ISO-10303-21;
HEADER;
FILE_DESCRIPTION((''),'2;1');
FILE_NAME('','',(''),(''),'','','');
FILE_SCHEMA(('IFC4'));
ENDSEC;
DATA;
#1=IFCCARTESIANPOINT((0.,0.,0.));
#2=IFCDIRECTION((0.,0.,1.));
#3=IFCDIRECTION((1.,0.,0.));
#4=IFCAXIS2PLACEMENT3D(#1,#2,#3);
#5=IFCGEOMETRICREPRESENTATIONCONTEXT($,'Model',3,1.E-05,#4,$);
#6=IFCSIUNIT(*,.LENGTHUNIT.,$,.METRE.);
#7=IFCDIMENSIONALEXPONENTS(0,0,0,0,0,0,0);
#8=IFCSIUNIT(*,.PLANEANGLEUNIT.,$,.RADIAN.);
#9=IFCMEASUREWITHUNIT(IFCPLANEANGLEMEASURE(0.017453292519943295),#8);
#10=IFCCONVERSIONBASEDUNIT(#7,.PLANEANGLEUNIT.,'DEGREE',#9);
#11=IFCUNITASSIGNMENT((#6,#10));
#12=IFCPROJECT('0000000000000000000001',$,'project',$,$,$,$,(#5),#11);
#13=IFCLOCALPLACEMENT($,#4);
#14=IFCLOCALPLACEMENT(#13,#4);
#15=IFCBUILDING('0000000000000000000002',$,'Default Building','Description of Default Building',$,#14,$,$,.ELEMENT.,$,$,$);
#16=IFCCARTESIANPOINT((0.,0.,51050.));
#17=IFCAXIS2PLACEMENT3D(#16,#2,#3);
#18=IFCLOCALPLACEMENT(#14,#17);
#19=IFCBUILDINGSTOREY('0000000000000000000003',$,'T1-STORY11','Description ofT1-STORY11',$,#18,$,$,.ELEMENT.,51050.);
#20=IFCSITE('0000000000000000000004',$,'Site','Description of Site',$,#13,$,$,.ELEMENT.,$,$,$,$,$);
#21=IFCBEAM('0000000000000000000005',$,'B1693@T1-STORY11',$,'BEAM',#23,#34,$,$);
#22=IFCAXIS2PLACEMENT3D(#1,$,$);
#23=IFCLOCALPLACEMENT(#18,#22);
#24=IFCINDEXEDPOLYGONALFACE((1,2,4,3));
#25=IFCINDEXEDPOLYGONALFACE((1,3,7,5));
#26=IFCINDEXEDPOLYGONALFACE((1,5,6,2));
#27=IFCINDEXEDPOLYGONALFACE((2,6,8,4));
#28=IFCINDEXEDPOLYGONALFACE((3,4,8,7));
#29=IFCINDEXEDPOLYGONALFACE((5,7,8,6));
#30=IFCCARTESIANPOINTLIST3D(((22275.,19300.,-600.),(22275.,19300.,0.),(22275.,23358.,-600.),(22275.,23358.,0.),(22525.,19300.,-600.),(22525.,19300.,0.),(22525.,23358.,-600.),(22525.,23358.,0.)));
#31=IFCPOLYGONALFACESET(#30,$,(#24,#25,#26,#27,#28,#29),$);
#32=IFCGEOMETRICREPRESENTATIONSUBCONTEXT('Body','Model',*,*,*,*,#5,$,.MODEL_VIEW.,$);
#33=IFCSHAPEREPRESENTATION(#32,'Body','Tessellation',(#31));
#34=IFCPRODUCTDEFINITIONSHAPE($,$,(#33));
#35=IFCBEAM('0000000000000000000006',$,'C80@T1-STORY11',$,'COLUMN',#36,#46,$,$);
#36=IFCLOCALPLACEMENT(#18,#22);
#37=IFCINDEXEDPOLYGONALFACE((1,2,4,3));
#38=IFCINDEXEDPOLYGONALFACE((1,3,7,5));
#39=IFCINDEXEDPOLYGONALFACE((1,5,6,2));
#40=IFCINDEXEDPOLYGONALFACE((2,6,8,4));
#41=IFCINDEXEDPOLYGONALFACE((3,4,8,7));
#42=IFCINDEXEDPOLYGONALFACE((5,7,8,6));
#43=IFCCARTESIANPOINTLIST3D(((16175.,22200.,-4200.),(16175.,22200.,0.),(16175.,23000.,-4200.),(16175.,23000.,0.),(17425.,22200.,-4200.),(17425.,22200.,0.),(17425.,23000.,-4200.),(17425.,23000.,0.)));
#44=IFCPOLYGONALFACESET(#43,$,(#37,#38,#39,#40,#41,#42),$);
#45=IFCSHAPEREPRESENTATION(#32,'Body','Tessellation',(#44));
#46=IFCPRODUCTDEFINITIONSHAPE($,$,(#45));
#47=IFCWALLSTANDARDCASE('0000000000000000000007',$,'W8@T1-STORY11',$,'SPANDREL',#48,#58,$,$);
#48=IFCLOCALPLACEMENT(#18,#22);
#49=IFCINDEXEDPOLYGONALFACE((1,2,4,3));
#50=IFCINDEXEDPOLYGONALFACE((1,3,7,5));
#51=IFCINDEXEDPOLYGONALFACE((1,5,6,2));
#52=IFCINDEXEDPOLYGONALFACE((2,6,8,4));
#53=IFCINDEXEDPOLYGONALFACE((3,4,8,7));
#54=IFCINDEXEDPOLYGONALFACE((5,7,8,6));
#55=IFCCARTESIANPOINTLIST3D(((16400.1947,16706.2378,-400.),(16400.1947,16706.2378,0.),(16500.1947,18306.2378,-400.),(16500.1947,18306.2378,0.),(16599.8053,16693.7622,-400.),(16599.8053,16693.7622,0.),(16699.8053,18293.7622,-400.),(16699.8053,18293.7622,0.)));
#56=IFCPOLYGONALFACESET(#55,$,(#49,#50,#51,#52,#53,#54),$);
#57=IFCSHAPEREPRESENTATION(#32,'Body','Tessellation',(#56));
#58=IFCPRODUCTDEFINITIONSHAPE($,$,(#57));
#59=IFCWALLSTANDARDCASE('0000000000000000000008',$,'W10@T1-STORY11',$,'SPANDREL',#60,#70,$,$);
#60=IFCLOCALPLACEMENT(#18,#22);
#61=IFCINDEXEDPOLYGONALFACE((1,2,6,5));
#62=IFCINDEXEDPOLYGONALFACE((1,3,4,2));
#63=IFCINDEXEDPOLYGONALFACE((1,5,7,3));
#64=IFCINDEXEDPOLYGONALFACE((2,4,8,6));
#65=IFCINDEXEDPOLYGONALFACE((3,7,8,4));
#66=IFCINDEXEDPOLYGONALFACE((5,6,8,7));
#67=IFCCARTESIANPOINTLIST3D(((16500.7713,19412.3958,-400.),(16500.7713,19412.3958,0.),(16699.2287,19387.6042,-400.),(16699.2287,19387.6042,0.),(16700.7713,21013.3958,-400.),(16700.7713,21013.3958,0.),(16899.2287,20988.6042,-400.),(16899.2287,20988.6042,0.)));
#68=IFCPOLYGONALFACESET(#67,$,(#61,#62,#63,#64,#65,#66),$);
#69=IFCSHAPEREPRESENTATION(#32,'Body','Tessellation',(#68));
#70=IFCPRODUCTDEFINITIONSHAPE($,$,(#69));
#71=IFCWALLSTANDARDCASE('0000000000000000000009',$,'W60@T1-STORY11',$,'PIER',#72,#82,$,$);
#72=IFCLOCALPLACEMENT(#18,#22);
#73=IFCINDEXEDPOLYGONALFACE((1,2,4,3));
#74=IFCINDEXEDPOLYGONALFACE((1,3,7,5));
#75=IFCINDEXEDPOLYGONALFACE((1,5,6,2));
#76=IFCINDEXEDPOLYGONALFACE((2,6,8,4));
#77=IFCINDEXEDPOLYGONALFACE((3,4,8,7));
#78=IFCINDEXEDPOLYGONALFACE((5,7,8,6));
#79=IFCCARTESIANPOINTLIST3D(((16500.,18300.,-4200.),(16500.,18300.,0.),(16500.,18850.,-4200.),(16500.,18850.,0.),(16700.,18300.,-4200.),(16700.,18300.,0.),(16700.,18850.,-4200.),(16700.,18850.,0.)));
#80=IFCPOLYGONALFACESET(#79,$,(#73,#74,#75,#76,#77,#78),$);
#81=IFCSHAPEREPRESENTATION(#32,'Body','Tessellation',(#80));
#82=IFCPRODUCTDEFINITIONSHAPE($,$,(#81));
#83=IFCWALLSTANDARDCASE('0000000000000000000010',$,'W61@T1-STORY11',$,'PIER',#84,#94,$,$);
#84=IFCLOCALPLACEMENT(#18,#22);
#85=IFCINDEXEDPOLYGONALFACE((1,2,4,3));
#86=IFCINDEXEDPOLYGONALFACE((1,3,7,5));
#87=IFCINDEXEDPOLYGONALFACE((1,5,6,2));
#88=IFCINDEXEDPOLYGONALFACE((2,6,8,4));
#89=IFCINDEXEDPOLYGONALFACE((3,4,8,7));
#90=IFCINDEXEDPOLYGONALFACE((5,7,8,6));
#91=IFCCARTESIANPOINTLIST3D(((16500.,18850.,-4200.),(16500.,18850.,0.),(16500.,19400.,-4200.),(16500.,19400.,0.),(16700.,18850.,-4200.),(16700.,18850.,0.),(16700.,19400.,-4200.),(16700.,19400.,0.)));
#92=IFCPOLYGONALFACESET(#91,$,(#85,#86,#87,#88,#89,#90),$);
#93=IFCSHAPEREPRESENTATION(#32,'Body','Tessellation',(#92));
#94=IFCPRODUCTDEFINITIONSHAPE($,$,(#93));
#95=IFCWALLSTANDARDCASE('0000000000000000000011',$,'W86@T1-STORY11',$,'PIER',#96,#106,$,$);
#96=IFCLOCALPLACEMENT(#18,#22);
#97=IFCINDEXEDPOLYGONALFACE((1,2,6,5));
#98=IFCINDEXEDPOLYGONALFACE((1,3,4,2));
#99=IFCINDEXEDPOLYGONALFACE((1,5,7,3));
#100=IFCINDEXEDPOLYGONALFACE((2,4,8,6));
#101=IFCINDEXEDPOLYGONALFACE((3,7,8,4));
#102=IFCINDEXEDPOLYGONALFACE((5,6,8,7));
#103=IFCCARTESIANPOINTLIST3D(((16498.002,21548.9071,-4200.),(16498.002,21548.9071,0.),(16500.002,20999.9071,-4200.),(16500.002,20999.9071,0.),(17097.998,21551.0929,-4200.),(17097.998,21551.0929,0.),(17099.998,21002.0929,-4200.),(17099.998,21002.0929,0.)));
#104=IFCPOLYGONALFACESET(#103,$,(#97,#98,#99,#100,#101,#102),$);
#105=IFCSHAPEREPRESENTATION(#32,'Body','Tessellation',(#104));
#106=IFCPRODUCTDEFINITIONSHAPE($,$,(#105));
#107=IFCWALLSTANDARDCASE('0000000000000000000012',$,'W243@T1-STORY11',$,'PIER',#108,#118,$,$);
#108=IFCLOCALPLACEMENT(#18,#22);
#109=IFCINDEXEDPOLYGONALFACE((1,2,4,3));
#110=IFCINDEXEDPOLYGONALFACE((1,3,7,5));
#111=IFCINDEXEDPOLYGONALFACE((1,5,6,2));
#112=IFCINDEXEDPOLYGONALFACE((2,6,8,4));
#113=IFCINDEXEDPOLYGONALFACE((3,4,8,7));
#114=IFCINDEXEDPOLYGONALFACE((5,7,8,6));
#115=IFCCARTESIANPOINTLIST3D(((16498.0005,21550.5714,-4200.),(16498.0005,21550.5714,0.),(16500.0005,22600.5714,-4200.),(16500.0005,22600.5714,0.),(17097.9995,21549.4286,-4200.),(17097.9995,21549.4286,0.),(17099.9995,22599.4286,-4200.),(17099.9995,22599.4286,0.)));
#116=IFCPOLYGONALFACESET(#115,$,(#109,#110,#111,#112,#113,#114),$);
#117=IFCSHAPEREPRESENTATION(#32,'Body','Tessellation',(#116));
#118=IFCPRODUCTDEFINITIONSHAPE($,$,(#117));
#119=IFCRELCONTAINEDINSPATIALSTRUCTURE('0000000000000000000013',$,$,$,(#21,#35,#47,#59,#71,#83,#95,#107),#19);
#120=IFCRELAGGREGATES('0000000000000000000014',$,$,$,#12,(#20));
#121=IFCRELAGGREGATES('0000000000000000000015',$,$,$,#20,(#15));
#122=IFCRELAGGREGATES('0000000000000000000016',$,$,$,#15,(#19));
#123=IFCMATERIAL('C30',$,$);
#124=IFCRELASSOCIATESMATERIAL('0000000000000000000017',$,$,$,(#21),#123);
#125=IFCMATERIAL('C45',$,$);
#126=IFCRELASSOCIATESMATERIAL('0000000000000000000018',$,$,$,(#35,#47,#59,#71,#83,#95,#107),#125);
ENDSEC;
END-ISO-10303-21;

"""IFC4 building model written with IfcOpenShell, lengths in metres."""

from ifc_helpers import new_model, entity, si_unit, converted_unit, frame, origin_with_axes, place, context, subcontext, project, spatial, indexed_curve, rectangle, outline, extrude, material, element, save


model = new_model("IFC4")

# Units and contexts
model_context = context("Model", 3, precision=1e-05, world=origin_with_axes())
body_context = subcontext(model_context, "Body", "Model", "MODEL_VIEW")
ifc_project = project(units=[si_unit("LENGTHUNIT", "METRE"), converted_unit("PLANEANGLEUNIT", "DEGREE", entity("IfcPlaneAngleMeasure", 0.017453292519943295), si_unit("PLANEANGLEUNIT", "RADIAN"), dimensions=[0, 0, 0, 0, 0, 0, 0])], contexts=[model_context])

# Site, building, storey
site_placement = place(None, origin_with_axes())
site = spatial("IfcSite", under=ifc_project, at=site_placement, Name="Site", Description="Description of Site", CompositionType="ELEMENT")
building_placement = place(site_placement, origin_with_axes())
building = spatial("IfcBuilding", under=site, at=building_placement, Name="Default Building", Description="Description of Default Building", CompositionType="ELEMENT")
storey_placement = place(building_placement, frame((0.0, 0.0, 51050.0), z_axis=(0.0, 0.0, 1.0), x_axis=(1.0, 0.0, 0.0)))
storey = spatial("IfcBuildingStorey", under=building, at=storey_placement, Name="T1-STORY11", Description="Description ofT1-STORY11", CompositionType="ELEMENT", Elevation=51050.0)

# Beams
ifc_material_1 = material(Name="C30")
beam_1_placement = place(storey_placement, frame((22400.0, 19300.0, -300.0), z_axis=(0.0, 1.0, 0.0), x_axis=(-1.0, 0.0, 0.0)))
element("IfcBeam", 1, at=beam_1_placement, inside=storey, material=ifc_material_1, Name="B1693@T1-STORY11", ObjectType="BEAM", context=body_context, shape_type="SweptSolid", body=[
    extrude(rectangle(XDim=250.0, YDim=600.0), origin_with_axes(), (0.0, 0.0, 1.0), 4058.0),
])
ifc_material_2 = material(Name="C45")
beam_2_placement = place(storey_placement, frame((16800.0, 22600.0, -4200.0), z_axis=(0.0, 0.0, 1.0), x_axis=(0.0, -1.0, 0.0)))
element("IfcBeam", 2, at=beam_2_placement, inside=storey, material=ifc_material_2, Name="C80@T1-STORY11", ObjectType="COLUMN", context=body_context, shape_type="SweptSolid", body=[
    extrude(rectangle(XDim=800.0, YDim=1250.0), origin_with_axes(), (0.0, 0.0, 1.0), 4200.0),
])

# Walls
wall_1_placement = place(storey_placement, frame((16500.0, 16700.0, -400.0), z_axis=(0.0, 0.0, 1.0), x_axis=(0.062378, 0.998053, 0.0)))
element("IfcWallStandardCase", 3, at=wall_1_placement, inside=storey, material=ifc_material_2, Name="W8@T1-STORY11", ObjectType="SPANDREL", context=body_context, shape_type="SweptSolid", body=[
    extrude(outline(indexed_curve([(0.0, -100.0), (0.0, 100.0), (1603.122, 100.0), (1603.122, -100.0), (0.0, -100.0)], self_intersect=False)), origin_with_axes(), (0.0, 0.0, 1.0), 400.0),
])
wall_2_placement = place(storey_placement, frame((16600.0, 19400.0, -400.0), z_axis=(0.0, 0.0, 1.0), x_axis=(0.123958, 0.992287, 0.0)))
element("IfcWallStandardCase", 4, at=wall_2_placement, inside=storey, material=ifc_material_2, Name="W10@T1-STORY11", ObjectType="SPANDREL", context=body_context, shape_type="SweptSolid", body=[
    extrude(outline(indexed_curve([(0.0, -100.0), (0.0, 100.0), (1613.4438, 100.0), (1613.4438, -100.0), (0.0, -100.0)], self_intersect=False)), origin_with_axes(), (0.0, 0.0, 1.0), 400.0),
])
for number, where, z_axis, x_axis, name in (
    (5, (16600.0, 18300.0, -4200.0), (0.0, 0.0, 1.0), (0.0, 1.0, 0.0), "W60@T1-STORY11"),
    (6, (16600.0, 18850.0, -4200.0), (0.0, 0.0, 1.0), (0.0, 1.0, 0.0), "W61@T1-STORY11"),
):
    element("IfcWallStandardCase", number, at=place(storey_placement, frame(where, z_axis=z_axis, x_axis=x_axis)), inside=storey, material=ifc_material_2, Name=name, ObjectType="PIER", context=body_context, shape_type="SweptSolid", body=[
        extrude(outline(indexed_curve([(0.0, -100.0), (0.0, 100.0), (550.0, 100.0), (550.0, -100.0), (0.0, -100.0)], self_intersect=False)), origin_with_axes(), (0.0, 0.0, 1.0), 4200.0),
    ])
wall_3_placement = place(storey_placement, frame((16800.0, 21001.0, -4200.0), z_axis=(0.0, 0.0, 1.0), x_axis=(-0.003643, 0.999993, 0.0)))
element("IfcWallStandardCase", 7, at=wall_3_placement, inside=storey, material=ifc_material_2, Name="W86@T1-STORY11", ObjectType="PIER", context=body_context, shape_type="SweptSolid", body=[
    extrude(outline(indexed_curve([(0.0, -300.0), (0.0, 300.0), (549.0036, 300.0), (549.0036, -300.0), (0.0, -300.0)], self_intersect=False)), origin_with_axes(), (0.0, 0.0, 1.0), 4200.0),
])
wall_4_placement = place(storey_placement, frame((16798.0, 21550.0, -4200.0), z_axis=(0.0, 0.0, 1.0), x_axis=(0.001905, 0.999998, 0.0)))
element("IfcWallStandardCase", 8, at=wall_4_placement, inside=storey, material=ifc_material_2, Name="W243@T1-STORY11", ObjectType="PIER", context=body_context, shape_type="SweptSolid", body=[
    extrude(outline(indexed_curve([(0.0, -300.0), (0.0, 300.0), (1050.0019, 300.0), (1050.0019, -300.0), (0.0, -300.0)], self_intersect=False)), origin_with_axes(), (0.0, 0.0, 1.0), 4200.0),
])

save(model, "model.ifc")
